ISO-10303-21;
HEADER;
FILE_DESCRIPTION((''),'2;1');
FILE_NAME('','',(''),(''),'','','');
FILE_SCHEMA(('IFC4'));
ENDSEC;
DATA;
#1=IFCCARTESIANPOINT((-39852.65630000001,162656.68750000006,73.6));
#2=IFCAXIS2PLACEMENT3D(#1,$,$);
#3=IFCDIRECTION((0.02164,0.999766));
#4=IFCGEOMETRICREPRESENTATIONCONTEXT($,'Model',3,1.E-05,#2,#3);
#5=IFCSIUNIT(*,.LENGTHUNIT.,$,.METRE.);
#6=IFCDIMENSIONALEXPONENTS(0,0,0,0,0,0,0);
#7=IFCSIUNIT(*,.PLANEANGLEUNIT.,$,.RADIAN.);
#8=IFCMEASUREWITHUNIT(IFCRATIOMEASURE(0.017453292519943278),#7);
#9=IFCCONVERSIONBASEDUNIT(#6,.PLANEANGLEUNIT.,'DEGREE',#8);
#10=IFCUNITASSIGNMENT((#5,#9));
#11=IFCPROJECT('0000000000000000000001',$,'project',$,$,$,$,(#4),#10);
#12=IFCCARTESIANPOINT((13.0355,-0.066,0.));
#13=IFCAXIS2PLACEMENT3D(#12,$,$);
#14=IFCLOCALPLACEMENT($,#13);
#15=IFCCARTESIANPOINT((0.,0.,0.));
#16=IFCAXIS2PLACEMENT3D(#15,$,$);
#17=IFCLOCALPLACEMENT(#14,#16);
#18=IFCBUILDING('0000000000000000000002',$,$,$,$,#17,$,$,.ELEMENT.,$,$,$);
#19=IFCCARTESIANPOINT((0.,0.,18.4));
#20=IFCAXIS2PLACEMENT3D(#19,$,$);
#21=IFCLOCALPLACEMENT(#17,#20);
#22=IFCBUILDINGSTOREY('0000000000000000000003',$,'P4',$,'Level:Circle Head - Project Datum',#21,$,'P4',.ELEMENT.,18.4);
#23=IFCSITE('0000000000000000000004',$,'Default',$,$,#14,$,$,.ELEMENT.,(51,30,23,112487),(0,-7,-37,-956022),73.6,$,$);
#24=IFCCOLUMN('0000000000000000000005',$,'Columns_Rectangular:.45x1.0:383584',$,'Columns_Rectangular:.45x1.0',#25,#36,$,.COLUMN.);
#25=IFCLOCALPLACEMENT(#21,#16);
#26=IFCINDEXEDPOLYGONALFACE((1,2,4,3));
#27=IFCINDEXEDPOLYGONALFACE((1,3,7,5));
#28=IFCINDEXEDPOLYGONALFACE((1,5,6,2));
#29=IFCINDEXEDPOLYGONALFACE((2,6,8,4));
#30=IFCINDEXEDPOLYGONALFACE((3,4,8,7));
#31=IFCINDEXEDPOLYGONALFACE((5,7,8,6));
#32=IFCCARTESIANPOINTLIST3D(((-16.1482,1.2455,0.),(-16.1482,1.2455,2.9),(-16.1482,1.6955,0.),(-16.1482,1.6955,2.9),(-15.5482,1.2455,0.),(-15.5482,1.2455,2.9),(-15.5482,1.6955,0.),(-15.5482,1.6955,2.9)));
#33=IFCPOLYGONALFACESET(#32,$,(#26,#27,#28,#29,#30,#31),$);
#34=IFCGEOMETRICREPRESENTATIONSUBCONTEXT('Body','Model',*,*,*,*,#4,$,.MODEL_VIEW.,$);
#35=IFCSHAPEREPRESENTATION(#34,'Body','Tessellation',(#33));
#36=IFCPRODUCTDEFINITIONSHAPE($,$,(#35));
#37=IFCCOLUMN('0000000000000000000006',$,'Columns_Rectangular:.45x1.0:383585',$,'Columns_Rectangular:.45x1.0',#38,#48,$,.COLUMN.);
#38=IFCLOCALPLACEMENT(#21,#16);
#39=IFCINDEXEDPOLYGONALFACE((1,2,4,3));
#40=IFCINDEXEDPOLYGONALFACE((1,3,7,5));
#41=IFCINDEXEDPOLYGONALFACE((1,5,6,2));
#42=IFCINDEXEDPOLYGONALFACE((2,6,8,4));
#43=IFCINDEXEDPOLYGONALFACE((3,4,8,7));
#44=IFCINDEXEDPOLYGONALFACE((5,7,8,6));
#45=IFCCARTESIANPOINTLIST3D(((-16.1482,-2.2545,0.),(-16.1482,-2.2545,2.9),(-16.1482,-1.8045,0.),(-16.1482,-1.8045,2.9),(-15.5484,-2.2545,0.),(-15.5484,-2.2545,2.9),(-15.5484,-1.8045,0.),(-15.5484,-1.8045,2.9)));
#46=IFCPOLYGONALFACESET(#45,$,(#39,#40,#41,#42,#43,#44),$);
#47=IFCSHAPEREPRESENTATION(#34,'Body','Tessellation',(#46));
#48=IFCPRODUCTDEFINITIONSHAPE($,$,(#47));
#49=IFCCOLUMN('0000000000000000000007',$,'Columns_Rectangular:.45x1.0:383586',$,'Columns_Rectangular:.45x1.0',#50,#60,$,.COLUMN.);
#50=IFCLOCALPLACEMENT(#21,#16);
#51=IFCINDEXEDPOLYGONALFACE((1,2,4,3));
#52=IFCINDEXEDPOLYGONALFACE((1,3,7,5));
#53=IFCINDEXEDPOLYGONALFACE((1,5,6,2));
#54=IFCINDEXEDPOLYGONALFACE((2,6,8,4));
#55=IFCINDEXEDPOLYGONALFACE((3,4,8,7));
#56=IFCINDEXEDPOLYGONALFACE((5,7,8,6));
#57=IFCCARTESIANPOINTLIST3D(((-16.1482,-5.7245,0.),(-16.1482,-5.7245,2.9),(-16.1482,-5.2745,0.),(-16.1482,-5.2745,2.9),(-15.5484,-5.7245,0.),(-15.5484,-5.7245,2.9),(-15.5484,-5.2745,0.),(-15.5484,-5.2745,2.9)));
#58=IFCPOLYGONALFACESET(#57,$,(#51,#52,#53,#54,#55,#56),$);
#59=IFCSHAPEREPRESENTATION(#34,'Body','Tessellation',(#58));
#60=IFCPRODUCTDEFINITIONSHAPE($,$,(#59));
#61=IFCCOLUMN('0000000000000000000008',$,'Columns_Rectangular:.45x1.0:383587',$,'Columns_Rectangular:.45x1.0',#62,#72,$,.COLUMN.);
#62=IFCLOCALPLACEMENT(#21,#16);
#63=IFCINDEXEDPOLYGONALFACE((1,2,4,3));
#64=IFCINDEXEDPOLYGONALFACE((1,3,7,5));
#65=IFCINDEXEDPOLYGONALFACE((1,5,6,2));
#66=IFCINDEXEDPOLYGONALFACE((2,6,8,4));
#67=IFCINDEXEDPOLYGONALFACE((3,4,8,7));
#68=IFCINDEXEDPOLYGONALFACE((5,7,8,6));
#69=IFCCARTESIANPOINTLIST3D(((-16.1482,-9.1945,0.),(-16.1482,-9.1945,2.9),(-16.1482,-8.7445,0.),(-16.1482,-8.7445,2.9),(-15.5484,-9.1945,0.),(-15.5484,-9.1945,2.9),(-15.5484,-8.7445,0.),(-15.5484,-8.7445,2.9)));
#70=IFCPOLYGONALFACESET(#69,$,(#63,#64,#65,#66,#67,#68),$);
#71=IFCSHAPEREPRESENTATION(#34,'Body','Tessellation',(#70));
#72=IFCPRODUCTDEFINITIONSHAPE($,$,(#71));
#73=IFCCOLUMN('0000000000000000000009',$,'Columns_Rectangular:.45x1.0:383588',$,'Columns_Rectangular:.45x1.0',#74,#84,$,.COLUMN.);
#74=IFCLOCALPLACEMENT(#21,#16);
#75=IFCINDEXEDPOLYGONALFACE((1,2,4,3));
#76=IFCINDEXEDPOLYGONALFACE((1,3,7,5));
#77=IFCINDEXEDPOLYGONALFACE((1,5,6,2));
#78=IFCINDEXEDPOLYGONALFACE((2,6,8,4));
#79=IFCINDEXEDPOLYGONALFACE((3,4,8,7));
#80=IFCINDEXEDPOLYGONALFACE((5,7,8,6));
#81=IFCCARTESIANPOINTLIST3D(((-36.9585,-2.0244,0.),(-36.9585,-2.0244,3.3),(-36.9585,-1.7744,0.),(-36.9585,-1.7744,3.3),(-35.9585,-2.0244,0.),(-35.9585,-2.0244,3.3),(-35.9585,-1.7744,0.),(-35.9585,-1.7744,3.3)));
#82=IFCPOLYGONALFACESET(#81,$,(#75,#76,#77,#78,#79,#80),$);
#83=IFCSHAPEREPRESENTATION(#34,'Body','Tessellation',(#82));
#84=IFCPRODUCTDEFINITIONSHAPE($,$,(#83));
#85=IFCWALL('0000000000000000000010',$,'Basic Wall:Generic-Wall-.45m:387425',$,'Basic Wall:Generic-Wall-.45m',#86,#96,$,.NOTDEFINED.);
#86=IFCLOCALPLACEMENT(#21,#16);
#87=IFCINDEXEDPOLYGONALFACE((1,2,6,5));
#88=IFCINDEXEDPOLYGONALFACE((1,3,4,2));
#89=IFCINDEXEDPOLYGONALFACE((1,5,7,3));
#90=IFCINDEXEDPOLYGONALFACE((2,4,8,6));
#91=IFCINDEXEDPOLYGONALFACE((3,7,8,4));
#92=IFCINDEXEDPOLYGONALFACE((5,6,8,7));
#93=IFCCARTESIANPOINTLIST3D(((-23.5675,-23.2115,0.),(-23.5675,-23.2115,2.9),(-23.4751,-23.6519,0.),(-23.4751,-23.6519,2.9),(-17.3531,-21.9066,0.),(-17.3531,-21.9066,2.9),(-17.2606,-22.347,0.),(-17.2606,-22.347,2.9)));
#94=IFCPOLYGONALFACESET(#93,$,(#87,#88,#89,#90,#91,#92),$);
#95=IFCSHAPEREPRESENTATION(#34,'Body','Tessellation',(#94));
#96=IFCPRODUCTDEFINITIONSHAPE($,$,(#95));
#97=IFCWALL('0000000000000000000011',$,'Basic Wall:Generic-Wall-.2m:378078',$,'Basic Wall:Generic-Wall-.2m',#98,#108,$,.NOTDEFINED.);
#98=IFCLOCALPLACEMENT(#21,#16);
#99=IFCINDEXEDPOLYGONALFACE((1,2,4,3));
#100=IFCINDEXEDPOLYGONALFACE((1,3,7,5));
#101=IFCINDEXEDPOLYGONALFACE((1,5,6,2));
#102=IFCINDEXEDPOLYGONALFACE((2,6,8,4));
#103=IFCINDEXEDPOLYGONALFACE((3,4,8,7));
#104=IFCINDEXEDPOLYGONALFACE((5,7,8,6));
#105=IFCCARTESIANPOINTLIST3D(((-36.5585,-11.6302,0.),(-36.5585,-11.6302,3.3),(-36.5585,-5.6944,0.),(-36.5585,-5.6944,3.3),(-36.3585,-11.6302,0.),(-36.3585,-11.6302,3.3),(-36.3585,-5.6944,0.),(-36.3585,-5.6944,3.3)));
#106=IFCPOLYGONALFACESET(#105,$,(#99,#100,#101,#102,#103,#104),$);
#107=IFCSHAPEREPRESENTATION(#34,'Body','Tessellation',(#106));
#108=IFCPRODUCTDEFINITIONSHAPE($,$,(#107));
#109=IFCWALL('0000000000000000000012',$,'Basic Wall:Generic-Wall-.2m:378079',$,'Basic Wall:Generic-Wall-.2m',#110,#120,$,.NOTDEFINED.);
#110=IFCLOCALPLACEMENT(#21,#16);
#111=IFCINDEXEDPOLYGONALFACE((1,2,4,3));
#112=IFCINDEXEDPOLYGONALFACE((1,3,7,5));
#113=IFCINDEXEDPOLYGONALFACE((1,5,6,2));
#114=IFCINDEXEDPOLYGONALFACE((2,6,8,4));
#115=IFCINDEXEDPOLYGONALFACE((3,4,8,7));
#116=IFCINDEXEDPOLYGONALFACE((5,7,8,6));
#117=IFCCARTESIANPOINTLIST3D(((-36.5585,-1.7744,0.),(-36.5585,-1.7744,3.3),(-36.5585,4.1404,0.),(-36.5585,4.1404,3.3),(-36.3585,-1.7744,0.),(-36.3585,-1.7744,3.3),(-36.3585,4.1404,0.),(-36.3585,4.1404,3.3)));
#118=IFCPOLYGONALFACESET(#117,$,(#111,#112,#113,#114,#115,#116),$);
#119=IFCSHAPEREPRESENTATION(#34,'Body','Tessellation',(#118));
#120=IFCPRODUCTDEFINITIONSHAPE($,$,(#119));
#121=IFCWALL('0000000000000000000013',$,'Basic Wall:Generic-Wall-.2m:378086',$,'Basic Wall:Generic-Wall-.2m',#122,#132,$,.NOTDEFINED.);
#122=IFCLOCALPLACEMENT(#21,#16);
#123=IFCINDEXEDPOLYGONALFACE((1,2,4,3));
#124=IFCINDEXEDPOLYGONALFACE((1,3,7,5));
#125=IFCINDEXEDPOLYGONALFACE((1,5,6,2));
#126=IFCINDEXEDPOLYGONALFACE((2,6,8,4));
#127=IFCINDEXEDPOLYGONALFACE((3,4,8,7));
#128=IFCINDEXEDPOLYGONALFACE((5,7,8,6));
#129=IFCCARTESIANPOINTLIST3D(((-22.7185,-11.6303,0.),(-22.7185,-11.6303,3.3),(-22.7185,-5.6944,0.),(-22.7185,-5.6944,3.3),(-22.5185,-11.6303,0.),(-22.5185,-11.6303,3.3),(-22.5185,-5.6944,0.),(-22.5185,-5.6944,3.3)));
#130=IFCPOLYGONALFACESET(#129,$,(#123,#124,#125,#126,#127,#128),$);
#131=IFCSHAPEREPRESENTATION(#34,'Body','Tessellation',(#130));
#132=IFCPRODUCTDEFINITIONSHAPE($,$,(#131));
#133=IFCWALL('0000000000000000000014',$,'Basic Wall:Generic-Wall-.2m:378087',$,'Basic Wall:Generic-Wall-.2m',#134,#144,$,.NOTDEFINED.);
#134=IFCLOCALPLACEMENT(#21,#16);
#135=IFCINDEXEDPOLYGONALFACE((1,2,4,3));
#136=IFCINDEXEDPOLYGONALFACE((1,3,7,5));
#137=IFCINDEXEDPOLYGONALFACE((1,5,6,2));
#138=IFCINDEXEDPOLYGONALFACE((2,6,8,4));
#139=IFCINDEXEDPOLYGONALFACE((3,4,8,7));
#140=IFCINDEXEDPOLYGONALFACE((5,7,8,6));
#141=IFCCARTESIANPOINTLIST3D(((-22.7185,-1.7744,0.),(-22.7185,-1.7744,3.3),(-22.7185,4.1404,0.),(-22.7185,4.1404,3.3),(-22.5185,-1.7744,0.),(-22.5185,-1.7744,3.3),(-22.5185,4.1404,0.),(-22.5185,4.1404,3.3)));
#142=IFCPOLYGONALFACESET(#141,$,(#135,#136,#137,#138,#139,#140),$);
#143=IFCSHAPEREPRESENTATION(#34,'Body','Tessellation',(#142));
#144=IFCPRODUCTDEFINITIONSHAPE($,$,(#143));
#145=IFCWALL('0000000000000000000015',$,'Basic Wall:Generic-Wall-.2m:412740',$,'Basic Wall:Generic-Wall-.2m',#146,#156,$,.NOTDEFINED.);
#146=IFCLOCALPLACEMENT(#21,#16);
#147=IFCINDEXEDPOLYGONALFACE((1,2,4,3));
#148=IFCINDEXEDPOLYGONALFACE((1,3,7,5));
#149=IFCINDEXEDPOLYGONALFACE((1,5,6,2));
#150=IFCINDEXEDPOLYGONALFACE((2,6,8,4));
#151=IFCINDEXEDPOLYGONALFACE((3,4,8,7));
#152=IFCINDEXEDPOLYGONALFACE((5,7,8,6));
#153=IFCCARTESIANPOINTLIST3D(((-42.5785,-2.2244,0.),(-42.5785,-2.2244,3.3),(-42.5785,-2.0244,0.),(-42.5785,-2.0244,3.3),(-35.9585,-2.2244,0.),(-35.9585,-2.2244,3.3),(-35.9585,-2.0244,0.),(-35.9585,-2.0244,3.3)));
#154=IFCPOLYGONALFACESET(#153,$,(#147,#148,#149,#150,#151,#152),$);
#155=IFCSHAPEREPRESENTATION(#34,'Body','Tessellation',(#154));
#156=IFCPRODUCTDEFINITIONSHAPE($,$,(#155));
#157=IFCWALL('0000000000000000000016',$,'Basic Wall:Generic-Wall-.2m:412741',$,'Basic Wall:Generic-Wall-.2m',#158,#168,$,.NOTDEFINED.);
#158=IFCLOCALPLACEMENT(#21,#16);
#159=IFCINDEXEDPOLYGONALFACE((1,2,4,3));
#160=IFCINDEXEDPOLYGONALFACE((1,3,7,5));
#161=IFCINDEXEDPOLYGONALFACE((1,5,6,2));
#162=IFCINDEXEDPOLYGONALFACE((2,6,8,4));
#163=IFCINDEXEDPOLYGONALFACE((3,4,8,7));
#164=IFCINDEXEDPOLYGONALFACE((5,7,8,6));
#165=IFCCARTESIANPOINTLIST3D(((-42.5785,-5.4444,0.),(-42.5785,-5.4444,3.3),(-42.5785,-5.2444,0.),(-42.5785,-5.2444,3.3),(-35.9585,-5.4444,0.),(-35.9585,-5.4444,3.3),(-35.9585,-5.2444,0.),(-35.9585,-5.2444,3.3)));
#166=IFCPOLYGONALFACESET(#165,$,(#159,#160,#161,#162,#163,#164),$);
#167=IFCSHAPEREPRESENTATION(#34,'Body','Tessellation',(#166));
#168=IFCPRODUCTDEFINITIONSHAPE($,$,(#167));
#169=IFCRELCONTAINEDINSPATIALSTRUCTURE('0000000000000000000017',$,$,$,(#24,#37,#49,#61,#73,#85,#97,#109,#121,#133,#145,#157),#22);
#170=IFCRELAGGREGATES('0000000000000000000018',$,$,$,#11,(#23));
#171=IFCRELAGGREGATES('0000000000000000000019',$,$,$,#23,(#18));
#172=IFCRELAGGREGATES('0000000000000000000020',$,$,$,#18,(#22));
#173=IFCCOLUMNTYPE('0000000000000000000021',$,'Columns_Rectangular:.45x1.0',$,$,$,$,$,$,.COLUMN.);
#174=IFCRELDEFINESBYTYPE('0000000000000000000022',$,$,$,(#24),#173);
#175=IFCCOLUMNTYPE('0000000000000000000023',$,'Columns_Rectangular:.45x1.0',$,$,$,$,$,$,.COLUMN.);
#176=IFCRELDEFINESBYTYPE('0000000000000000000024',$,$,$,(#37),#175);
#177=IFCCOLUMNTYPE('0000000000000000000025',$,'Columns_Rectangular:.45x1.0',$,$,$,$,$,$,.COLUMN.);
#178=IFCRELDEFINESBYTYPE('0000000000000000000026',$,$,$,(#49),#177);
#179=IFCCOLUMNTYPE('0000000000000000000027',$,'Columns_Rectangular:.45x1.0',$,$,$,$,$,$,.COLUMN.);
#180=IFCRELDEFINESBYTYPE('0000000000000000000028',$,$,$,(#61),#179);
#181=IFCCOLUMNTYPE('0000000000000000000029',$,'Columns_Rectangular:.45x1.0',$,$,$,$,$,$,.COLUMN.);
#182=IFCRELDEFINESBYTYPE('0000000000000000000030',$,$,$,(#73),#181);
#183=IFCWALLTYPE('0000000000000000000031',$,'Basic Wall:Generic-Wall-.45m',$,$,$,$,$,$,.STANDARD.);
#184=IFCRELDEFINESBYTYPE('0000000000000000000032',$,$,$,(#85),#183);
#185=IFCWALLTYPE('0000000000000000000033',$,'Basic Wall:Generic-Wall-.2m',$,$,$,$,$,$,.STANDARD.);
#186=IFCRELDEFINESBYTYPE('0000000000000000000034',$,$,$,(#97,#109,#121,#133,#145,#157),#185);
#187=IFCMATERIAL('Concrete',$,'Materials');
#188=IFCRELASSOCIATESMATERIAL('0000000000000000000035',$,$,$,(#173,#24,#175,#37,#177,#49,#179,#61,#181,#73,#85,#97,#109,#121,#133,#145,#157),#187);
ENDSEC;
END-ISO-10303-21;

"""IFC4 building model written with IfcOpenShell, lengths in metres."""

from ifc_helpers import new_model, entity, si_unit, converted_unit, direction, frame, origin, place, context, subcontext, project, spatial, indexed_curve, outline, extrude, source, transform, mapped, material, type_object, type_shapes, element, save


model = new_model("IFC4")

# Units and contexts
model_context = context("Model", 3, precision=1e-05, world=frame((-39852.65630000001, 162656.68750000006, 73.6)), true_north=direction((0.02164, 0.999766)))
body_context = subcontext(model_context, "Body", "Model", "MODEL_VIEW")
ifc_project = project(units=[si_unit("LENGTHUNIT", "METRE"), converted_unit("PLANEANGLEUNIT", "DEGREE", entity("IfcRatioMeasure", 0.017453292519943278), si_unit("PLANEANGLEUNIT", "RADIAN"), dimensions=[0, 0, 0, 0, 0, 0, 0])], contexts=[model_context])

# Site, building, storey
site_placement = place(None, frame((13.0355, -0.066, 0.0)))
site = spatial("IfcSite", under=ifc_project, at=site_placement, Name="Default", CompositionType="ELEMENT", RefLatitude=(51, 30, 23, 112487), RefLongitude=(0, -7, -37, -956022), RefElevation=73.6)
building_placement = place(site_placement, origin())
building = spatial("IfcBuilding", under=site, at=building_placement, CompositionType="ELEMENT")
storey_placement = place(building_placement, frame((0.0, 0.0, 18.4)))
storey = spatial("IfcBuildingStorey", under=building, at=storey_placement, Name="P4", ObjectType="Level:Circle Head - Project Datum", LongName="P4", CompositionType="ELEMENT", Elevation=18.4)

# Columns
ifc_material = material(Name="Concrete", Category="Materials")
column_type_1 = type_object("IfcColumnType", Name="Columns_Rectangular:.45x1.0", PredefinedType="COLUMN", material=ifc_material)
shared_shape_1 = source(origin(), body_context, "Body", "SweptSolid", [
    extrude(outline(indexed_curve([(-0.225, -0.3), (0.225, -0.3), (0.225, 0.3), (-0.225, 0.3), (-0.225, -0.3)], self_intersect=False)), frame((-15.8482, 1.4705, 18.4), z_axis=(0.0, 0.0, 1.0), x_axis=(0.0, -1.0, 0.0)), (0.0, 0.0, 1.0), 2.9),
])
type_shapes(column_type_1, [shared_shape_1])
column_1_placement = place(storey_placement, frame((0.0, 0.0, -18.4)))
element("IfcColumn", 1, at=column_1_placement, inside=storey, type_object=column_type_1, material=ifc_material, Name="Columns_Rectangular:.45x1.0:383584", ObjectType="Columns_Rectangular:.45x1.0", PredefinedType="COLUMN", context=body_context, shape_type="MappedRepresentation", body=[
    mapped(shared_shape_1, transform((0.0, 0.0, 0.0), scale=1.0)),
])
column_type_2 = type_object("IfcColumnType", Name="Columns_Rectangular:.45x1.0", PredefinedType="COLUMN", material=ifc_material)
shared_shape_2 = source(origin(), body_context, "Body", "SweptSolid", [
    extrude(outline(indexed_curve([(-0.225, -0.2999), (0.225, -0.2999), (0.225, 0.2999), (-0.225, 0.2999), (-0.225, -0.2999)], self_intersect=False)), frame((-15.8483, -2.0295, 18.4), z_axis=(0.0, 0.0, 1.0), x_axis=(0.0, -1.0, 0.0)), (0.0, 0.0, 1.0), 2.9),
])
type_shapes(column_type_2, [shared_shape_2])
column_2_placement = place(storey_placement, frame((0.0, 0.0, -18.4)))
element("IfcColumn", 2, at=column_2_placement, inside=storey, type_object=column_type_2, material=ifc_material, Name="Columns_Rectangular:.45x1.0:383585", ObjectType="Columns_Rectangular:.45x1.0", PredefinedType="COLUMN", context=body_context, shape_type="MappedRepresentation", body=[
    mapped(shared_shape_2, transform((0.0, 0.0, 0.0), scale=1.0)),
])
column_type_3 = type_object("IfcColumnType", Name="Columns_Rectangular:.45x1.0", PredefinedType="COLUMN", material=ifc_material)
shared_shape_3 = source(origin(), body_context, "Body", "SweptSolid", [
    extrude(outline(indexed_curve([(-0.225, -0.2999), (0.225, -0.2999), (0.225, 0.2999), (-0.225, 0.2999), (-0.225, -0.2999)], self_intersect=False)), frame((-15.8483, -5.4995, 18.4), z_axis=(0.0, 0.0, 1.0), x_axis=(0.0, -1.0, 0.0)), (0.0, 0.0, 1.0), 2.9),
])
type_shapes(column_type_3, [shared_shape_3])
column_3_placement = place(storey_placement, frame((0.0, 0.0, -18.4)))
element("IfcColumn", 3, at=column_3_placement, inside=storey, type_object=column_type_3, material=ifc_material, Name="Columns_Rectangular:.45x1.0:383586", ObjectType="Columns_Rectangular:.45x1.0", PredefinedType="COLUMN", context=body_context, shape_type="MappedRepresentation", body=[
    mapped(shared_shape_3, transform((0.0, 0.0, 0.0), scale=1.0)),
])
column_type_4 = type_object("IfcColumnType", Name="Columns_Rectangular:.45x1.0", PredefinedType="COLUMN", material=ifc_material)
shared_shape_4 = source(origin(), body_context, "Body", "SweptSolid", [
    extrude(outline(indexed_curve([(-0.225, -0.2999), (0.225, -0.2999), (0.225, 0.2999), (-0.225, 0.2999), (-0.225, -0.2999)], self_intersect=False)), frame((-15.8483, -8.9695, 18.4), z_axis=(0.0, 0.0, 1.0), x_axis=(0.0, -1.0, 0.0)), (0.0, 0.0, 1.0), 2.9),
])
type_shapes(column_type_4, [shared_shape_4])
column_4_placement = place(storey_placement, frame((0.0, 0.0, -18.4)))
element("IfcColumn", 4, at=column_4_placement, inside=storey, type_object=column_type_4, material=ifc_material, Name="Columns_Rectangular:.45x1.0:383587", ObjectType="Columns_Rectangular:.45x1.0", PredefinedType="COLUMN", context=body_context, shape_type="MappedRepresentation", body=[
    mapped(shared_shape_4, transform((0.0, 0.0, 0.0), scale=1.0)),
])
column_type_5 = type_object("IfcColumnType", Name="Columns_Rectangular:.45x1.0", PredefinedType="COLUMN", material=ifc_material)
shared_shape_5 = source(origin(), body_context, "Body", "SweptSolid", [
    extrude(outline(indexed_curve([(-0.125, -0.5), (0.125, -0.5), (0.125, 0.5), (-0.125, 0.5), (-0.125, -0.5)], self_intersect=False)), frame((-36.4585, -1.8994, 18.4), z_axis=(0.0, 0.0, 1.0), x_axis=(0.0, -1.0, 0.0)), (0.0, 0.0, 1.0), 3.3),
])
type_shapes(column_type_5, [shared_shape_5])
column_5_placement = place(storey_placement, frame((0.0, 0.0, -18.4)))
element("IfcColumn", 5, at=column_5_placement, inside=storey, type_object=column_type_5, material=ifc_material, Name="Columns_Rectangular:.45x1.0:383588", ObjectType="Columns_Rectangular:.45x1.0", PredefinedType="COLUMN", context=body_context, shape_type="MappedRepresentation", body=[
    mapped(shared_shape_5, transform((0.0, 0.0, 0.0), scale=1.0)),
])

# Walls
wall_type_1 = type_object("IfcWallType", Name="Basic Wall:Generic-Wall-.45m", PredefinedType="STANDARD")
wall_1_placement = place(storey_placement, frame((-23.5213, -23.4317, 0.0), z_axis=(0.0, 0.0, 1.0), x_axis=(0.978657, 0.2055, 0.0)))
element("IfcWall", 6, at=wall_1_placement, inside=storey, type_object=wall_type_1, material=ifc_material, Name="Basic Wall:Generic-Wall-.45m:387425", ObjectType="Basic Wall:Generic-Wall-.45m", PredefinedType="NOTDEFINED", context=body_context, shape_type="SweptSolid", body=[
    extrude(outline(indexed_curve([(6.35, 0.225), (0.0, 0.225), (0.0, -0.225), (6.35, -0.225), (6.35, 0.225)], self_intersect=False)), origin(), (0.0, 0.0, 1.0), 2.9),
])
wall_type_2 = type_object("IfcWallType", Name="Basic Wall:Generic-Wall-.2m", PredefinedType="STANDARD")
wall_2_placement = place(storey_placement, frame((-36.4585, -5.6944, 0.0), z_axis=(0.0, 0.0, 1.0), x_axis=(0.0, -1.0, 0.0)))
element("IfcWall", 7, at=wall_2_placement, inside=storey, type_object=wall_type_2, material=ifc_material, Name="Basic Wall:Generic-Wall-.2m:378078", ObjectType="Basic Wall:Generic-Wall-.2m", PredefinedType="NOTDEFINED", context=body_context, shape_type="SweptSolid", body=[
    extrude(outline(indexed_curve([(5.9357, 0.1), (0.0, 0.1), (0.0, -0.1), (5.9357, -0.1), (5.9357, 0.1)], self_intersect=False)), origin(), (0.0, 0.0, 1.0), 3.3),
])
wall_3_placement = place(storey_placement, frame((-36.4585, -1.7744, 0.0), z_axis=(0.0, 0.0, 1.0), x_axis=(0.0, 1.0, 0.0)))
element("IfcWall", 8, at=wall_3_placement, inside=storey, type_object=wall_type_2, material=ifc_material, Name="Basic Wall:Generic-Wall-.2m:378079", ObjectType="Basic Wall:Generic-Wall-.2m", PredefinedType="NOTDEFINED", context=body_context, shape_type="SweptSolid", body=[
    extrude(outline(indexed_curve([(5.9149, 0.1), (0.0, 0.1), (0.0, -0.1), (5.9149, -0.1), (5.9149, 0.1)], self_intersect=False)), origin(), (0.0, 0.0, 1.0), 3.3),
])
wall_4_placement = place(storey_placement, frame((-22.6185, -5.6944, 0.0), z_axis=(0.0, 0.0, 1.0), x_axis=(0.0, -1.0, 0.0)))
element("IfcWall", 9, at=wall_4_placement, inside=storey, type_object=wall_type_2, material=ifc_material, Name="Basic Wall:Generic-Wall-.2m:378086", ObjectType="Basic Wall:Generic-Wall-.2m", PredefinedType="NOTDEFINED", context=body_context, shape_type="SweptSolid", body=[
    extrude(outline(indexed_curve([(5.9359, 0.1), (0.0, 0.1), (0.0, -0.1), (5.9359, -0.1), (5.9359, 0.1)], self_intersect=False)), origin(), (0.0, 0.0, 1.0), 3.3),
])
wall_5_placement = place(storey_placement, frame((-22.6185, -1.7744, 0.0), z_axis=(0.0, 0.0, 1.0), x_axis=(0.0, 1.0, 0.0)))
element("IfcWall", 10, at=wall_5_placement, inside=storey, type_object=wall_type_2, material=ifc_material, Name="Basic Wall:Generic-Wall-.2m:378087", ObjectType="Basic Wall:Generic-Wall-.2m", PredefinedType="NOTDEFINED", context=body_context, shape_type="SweptSolid", body=[
    extrude(outline(indexed_curve([(5.9149, 0.1), (0.0, 0.1), (0.0, -0.1), (5.9149, -0.1), (5.9149, 0.1)], self_intersect=False)), origin(), (0.0, 0.0, 1.0), 3.3),
])
wall_6_placement = place(storey_placement, frame((-35.9585, -2.1244, 0.0), z_axis=(0.0, 0.0, 1.0), x_axis=(-1.0, 0.0, 0.0)))
element("IfcWall", 11, at=wall_6_placement, inside=storey, type_object=wall_type_2, material=ifc_material, Name="Basic Wall:Generic-Wall-.2m:412740", ObjectType="Basic Wall:Generic-Wall-.2m", PredefinedType="NOTDEFINED", context=body_context, shape_type="SweptSolid", body=[
    extrude(outline(indexed_curve([(6.6201, 0.1), (0.0, 0.1), (0.0, -0.1), (6.6201, -0.1), (6.6201, 0.1)], self_intersect=False)), origin(), (0.0, 0.0, 1.0), 3.3),
])
wall_7_placement = place(storey_placement, frame((-35.9585, -5.3444, 0.0), z_axis=(0.0, 0.0, 1.0), x_axis=(-1.0, 0.0, 0.0)))
element("IfcWall", 12, at=wall_7_placement, inside=storey, type_object=wall_type_2, material=ifc_material, Name="Basic Wall:Generic-Wall-.2m:412741", ObjectType="Basic Wall:Generic-Wall-.2m", PredefinedType="NOTDEFINED", context=body_context, shape_type="SweptSolid", body=[
    extrude(outline(indexed_curve([(6.62, 0.1), (0.0, 0.1), (0.0, -0.1), (6.62, -0.1), (6.62, 0.1)], self_intersect=False)), origin(), (0.0, 0.0, 1.0), 3.3),
])

save(model, "model.ifc")
